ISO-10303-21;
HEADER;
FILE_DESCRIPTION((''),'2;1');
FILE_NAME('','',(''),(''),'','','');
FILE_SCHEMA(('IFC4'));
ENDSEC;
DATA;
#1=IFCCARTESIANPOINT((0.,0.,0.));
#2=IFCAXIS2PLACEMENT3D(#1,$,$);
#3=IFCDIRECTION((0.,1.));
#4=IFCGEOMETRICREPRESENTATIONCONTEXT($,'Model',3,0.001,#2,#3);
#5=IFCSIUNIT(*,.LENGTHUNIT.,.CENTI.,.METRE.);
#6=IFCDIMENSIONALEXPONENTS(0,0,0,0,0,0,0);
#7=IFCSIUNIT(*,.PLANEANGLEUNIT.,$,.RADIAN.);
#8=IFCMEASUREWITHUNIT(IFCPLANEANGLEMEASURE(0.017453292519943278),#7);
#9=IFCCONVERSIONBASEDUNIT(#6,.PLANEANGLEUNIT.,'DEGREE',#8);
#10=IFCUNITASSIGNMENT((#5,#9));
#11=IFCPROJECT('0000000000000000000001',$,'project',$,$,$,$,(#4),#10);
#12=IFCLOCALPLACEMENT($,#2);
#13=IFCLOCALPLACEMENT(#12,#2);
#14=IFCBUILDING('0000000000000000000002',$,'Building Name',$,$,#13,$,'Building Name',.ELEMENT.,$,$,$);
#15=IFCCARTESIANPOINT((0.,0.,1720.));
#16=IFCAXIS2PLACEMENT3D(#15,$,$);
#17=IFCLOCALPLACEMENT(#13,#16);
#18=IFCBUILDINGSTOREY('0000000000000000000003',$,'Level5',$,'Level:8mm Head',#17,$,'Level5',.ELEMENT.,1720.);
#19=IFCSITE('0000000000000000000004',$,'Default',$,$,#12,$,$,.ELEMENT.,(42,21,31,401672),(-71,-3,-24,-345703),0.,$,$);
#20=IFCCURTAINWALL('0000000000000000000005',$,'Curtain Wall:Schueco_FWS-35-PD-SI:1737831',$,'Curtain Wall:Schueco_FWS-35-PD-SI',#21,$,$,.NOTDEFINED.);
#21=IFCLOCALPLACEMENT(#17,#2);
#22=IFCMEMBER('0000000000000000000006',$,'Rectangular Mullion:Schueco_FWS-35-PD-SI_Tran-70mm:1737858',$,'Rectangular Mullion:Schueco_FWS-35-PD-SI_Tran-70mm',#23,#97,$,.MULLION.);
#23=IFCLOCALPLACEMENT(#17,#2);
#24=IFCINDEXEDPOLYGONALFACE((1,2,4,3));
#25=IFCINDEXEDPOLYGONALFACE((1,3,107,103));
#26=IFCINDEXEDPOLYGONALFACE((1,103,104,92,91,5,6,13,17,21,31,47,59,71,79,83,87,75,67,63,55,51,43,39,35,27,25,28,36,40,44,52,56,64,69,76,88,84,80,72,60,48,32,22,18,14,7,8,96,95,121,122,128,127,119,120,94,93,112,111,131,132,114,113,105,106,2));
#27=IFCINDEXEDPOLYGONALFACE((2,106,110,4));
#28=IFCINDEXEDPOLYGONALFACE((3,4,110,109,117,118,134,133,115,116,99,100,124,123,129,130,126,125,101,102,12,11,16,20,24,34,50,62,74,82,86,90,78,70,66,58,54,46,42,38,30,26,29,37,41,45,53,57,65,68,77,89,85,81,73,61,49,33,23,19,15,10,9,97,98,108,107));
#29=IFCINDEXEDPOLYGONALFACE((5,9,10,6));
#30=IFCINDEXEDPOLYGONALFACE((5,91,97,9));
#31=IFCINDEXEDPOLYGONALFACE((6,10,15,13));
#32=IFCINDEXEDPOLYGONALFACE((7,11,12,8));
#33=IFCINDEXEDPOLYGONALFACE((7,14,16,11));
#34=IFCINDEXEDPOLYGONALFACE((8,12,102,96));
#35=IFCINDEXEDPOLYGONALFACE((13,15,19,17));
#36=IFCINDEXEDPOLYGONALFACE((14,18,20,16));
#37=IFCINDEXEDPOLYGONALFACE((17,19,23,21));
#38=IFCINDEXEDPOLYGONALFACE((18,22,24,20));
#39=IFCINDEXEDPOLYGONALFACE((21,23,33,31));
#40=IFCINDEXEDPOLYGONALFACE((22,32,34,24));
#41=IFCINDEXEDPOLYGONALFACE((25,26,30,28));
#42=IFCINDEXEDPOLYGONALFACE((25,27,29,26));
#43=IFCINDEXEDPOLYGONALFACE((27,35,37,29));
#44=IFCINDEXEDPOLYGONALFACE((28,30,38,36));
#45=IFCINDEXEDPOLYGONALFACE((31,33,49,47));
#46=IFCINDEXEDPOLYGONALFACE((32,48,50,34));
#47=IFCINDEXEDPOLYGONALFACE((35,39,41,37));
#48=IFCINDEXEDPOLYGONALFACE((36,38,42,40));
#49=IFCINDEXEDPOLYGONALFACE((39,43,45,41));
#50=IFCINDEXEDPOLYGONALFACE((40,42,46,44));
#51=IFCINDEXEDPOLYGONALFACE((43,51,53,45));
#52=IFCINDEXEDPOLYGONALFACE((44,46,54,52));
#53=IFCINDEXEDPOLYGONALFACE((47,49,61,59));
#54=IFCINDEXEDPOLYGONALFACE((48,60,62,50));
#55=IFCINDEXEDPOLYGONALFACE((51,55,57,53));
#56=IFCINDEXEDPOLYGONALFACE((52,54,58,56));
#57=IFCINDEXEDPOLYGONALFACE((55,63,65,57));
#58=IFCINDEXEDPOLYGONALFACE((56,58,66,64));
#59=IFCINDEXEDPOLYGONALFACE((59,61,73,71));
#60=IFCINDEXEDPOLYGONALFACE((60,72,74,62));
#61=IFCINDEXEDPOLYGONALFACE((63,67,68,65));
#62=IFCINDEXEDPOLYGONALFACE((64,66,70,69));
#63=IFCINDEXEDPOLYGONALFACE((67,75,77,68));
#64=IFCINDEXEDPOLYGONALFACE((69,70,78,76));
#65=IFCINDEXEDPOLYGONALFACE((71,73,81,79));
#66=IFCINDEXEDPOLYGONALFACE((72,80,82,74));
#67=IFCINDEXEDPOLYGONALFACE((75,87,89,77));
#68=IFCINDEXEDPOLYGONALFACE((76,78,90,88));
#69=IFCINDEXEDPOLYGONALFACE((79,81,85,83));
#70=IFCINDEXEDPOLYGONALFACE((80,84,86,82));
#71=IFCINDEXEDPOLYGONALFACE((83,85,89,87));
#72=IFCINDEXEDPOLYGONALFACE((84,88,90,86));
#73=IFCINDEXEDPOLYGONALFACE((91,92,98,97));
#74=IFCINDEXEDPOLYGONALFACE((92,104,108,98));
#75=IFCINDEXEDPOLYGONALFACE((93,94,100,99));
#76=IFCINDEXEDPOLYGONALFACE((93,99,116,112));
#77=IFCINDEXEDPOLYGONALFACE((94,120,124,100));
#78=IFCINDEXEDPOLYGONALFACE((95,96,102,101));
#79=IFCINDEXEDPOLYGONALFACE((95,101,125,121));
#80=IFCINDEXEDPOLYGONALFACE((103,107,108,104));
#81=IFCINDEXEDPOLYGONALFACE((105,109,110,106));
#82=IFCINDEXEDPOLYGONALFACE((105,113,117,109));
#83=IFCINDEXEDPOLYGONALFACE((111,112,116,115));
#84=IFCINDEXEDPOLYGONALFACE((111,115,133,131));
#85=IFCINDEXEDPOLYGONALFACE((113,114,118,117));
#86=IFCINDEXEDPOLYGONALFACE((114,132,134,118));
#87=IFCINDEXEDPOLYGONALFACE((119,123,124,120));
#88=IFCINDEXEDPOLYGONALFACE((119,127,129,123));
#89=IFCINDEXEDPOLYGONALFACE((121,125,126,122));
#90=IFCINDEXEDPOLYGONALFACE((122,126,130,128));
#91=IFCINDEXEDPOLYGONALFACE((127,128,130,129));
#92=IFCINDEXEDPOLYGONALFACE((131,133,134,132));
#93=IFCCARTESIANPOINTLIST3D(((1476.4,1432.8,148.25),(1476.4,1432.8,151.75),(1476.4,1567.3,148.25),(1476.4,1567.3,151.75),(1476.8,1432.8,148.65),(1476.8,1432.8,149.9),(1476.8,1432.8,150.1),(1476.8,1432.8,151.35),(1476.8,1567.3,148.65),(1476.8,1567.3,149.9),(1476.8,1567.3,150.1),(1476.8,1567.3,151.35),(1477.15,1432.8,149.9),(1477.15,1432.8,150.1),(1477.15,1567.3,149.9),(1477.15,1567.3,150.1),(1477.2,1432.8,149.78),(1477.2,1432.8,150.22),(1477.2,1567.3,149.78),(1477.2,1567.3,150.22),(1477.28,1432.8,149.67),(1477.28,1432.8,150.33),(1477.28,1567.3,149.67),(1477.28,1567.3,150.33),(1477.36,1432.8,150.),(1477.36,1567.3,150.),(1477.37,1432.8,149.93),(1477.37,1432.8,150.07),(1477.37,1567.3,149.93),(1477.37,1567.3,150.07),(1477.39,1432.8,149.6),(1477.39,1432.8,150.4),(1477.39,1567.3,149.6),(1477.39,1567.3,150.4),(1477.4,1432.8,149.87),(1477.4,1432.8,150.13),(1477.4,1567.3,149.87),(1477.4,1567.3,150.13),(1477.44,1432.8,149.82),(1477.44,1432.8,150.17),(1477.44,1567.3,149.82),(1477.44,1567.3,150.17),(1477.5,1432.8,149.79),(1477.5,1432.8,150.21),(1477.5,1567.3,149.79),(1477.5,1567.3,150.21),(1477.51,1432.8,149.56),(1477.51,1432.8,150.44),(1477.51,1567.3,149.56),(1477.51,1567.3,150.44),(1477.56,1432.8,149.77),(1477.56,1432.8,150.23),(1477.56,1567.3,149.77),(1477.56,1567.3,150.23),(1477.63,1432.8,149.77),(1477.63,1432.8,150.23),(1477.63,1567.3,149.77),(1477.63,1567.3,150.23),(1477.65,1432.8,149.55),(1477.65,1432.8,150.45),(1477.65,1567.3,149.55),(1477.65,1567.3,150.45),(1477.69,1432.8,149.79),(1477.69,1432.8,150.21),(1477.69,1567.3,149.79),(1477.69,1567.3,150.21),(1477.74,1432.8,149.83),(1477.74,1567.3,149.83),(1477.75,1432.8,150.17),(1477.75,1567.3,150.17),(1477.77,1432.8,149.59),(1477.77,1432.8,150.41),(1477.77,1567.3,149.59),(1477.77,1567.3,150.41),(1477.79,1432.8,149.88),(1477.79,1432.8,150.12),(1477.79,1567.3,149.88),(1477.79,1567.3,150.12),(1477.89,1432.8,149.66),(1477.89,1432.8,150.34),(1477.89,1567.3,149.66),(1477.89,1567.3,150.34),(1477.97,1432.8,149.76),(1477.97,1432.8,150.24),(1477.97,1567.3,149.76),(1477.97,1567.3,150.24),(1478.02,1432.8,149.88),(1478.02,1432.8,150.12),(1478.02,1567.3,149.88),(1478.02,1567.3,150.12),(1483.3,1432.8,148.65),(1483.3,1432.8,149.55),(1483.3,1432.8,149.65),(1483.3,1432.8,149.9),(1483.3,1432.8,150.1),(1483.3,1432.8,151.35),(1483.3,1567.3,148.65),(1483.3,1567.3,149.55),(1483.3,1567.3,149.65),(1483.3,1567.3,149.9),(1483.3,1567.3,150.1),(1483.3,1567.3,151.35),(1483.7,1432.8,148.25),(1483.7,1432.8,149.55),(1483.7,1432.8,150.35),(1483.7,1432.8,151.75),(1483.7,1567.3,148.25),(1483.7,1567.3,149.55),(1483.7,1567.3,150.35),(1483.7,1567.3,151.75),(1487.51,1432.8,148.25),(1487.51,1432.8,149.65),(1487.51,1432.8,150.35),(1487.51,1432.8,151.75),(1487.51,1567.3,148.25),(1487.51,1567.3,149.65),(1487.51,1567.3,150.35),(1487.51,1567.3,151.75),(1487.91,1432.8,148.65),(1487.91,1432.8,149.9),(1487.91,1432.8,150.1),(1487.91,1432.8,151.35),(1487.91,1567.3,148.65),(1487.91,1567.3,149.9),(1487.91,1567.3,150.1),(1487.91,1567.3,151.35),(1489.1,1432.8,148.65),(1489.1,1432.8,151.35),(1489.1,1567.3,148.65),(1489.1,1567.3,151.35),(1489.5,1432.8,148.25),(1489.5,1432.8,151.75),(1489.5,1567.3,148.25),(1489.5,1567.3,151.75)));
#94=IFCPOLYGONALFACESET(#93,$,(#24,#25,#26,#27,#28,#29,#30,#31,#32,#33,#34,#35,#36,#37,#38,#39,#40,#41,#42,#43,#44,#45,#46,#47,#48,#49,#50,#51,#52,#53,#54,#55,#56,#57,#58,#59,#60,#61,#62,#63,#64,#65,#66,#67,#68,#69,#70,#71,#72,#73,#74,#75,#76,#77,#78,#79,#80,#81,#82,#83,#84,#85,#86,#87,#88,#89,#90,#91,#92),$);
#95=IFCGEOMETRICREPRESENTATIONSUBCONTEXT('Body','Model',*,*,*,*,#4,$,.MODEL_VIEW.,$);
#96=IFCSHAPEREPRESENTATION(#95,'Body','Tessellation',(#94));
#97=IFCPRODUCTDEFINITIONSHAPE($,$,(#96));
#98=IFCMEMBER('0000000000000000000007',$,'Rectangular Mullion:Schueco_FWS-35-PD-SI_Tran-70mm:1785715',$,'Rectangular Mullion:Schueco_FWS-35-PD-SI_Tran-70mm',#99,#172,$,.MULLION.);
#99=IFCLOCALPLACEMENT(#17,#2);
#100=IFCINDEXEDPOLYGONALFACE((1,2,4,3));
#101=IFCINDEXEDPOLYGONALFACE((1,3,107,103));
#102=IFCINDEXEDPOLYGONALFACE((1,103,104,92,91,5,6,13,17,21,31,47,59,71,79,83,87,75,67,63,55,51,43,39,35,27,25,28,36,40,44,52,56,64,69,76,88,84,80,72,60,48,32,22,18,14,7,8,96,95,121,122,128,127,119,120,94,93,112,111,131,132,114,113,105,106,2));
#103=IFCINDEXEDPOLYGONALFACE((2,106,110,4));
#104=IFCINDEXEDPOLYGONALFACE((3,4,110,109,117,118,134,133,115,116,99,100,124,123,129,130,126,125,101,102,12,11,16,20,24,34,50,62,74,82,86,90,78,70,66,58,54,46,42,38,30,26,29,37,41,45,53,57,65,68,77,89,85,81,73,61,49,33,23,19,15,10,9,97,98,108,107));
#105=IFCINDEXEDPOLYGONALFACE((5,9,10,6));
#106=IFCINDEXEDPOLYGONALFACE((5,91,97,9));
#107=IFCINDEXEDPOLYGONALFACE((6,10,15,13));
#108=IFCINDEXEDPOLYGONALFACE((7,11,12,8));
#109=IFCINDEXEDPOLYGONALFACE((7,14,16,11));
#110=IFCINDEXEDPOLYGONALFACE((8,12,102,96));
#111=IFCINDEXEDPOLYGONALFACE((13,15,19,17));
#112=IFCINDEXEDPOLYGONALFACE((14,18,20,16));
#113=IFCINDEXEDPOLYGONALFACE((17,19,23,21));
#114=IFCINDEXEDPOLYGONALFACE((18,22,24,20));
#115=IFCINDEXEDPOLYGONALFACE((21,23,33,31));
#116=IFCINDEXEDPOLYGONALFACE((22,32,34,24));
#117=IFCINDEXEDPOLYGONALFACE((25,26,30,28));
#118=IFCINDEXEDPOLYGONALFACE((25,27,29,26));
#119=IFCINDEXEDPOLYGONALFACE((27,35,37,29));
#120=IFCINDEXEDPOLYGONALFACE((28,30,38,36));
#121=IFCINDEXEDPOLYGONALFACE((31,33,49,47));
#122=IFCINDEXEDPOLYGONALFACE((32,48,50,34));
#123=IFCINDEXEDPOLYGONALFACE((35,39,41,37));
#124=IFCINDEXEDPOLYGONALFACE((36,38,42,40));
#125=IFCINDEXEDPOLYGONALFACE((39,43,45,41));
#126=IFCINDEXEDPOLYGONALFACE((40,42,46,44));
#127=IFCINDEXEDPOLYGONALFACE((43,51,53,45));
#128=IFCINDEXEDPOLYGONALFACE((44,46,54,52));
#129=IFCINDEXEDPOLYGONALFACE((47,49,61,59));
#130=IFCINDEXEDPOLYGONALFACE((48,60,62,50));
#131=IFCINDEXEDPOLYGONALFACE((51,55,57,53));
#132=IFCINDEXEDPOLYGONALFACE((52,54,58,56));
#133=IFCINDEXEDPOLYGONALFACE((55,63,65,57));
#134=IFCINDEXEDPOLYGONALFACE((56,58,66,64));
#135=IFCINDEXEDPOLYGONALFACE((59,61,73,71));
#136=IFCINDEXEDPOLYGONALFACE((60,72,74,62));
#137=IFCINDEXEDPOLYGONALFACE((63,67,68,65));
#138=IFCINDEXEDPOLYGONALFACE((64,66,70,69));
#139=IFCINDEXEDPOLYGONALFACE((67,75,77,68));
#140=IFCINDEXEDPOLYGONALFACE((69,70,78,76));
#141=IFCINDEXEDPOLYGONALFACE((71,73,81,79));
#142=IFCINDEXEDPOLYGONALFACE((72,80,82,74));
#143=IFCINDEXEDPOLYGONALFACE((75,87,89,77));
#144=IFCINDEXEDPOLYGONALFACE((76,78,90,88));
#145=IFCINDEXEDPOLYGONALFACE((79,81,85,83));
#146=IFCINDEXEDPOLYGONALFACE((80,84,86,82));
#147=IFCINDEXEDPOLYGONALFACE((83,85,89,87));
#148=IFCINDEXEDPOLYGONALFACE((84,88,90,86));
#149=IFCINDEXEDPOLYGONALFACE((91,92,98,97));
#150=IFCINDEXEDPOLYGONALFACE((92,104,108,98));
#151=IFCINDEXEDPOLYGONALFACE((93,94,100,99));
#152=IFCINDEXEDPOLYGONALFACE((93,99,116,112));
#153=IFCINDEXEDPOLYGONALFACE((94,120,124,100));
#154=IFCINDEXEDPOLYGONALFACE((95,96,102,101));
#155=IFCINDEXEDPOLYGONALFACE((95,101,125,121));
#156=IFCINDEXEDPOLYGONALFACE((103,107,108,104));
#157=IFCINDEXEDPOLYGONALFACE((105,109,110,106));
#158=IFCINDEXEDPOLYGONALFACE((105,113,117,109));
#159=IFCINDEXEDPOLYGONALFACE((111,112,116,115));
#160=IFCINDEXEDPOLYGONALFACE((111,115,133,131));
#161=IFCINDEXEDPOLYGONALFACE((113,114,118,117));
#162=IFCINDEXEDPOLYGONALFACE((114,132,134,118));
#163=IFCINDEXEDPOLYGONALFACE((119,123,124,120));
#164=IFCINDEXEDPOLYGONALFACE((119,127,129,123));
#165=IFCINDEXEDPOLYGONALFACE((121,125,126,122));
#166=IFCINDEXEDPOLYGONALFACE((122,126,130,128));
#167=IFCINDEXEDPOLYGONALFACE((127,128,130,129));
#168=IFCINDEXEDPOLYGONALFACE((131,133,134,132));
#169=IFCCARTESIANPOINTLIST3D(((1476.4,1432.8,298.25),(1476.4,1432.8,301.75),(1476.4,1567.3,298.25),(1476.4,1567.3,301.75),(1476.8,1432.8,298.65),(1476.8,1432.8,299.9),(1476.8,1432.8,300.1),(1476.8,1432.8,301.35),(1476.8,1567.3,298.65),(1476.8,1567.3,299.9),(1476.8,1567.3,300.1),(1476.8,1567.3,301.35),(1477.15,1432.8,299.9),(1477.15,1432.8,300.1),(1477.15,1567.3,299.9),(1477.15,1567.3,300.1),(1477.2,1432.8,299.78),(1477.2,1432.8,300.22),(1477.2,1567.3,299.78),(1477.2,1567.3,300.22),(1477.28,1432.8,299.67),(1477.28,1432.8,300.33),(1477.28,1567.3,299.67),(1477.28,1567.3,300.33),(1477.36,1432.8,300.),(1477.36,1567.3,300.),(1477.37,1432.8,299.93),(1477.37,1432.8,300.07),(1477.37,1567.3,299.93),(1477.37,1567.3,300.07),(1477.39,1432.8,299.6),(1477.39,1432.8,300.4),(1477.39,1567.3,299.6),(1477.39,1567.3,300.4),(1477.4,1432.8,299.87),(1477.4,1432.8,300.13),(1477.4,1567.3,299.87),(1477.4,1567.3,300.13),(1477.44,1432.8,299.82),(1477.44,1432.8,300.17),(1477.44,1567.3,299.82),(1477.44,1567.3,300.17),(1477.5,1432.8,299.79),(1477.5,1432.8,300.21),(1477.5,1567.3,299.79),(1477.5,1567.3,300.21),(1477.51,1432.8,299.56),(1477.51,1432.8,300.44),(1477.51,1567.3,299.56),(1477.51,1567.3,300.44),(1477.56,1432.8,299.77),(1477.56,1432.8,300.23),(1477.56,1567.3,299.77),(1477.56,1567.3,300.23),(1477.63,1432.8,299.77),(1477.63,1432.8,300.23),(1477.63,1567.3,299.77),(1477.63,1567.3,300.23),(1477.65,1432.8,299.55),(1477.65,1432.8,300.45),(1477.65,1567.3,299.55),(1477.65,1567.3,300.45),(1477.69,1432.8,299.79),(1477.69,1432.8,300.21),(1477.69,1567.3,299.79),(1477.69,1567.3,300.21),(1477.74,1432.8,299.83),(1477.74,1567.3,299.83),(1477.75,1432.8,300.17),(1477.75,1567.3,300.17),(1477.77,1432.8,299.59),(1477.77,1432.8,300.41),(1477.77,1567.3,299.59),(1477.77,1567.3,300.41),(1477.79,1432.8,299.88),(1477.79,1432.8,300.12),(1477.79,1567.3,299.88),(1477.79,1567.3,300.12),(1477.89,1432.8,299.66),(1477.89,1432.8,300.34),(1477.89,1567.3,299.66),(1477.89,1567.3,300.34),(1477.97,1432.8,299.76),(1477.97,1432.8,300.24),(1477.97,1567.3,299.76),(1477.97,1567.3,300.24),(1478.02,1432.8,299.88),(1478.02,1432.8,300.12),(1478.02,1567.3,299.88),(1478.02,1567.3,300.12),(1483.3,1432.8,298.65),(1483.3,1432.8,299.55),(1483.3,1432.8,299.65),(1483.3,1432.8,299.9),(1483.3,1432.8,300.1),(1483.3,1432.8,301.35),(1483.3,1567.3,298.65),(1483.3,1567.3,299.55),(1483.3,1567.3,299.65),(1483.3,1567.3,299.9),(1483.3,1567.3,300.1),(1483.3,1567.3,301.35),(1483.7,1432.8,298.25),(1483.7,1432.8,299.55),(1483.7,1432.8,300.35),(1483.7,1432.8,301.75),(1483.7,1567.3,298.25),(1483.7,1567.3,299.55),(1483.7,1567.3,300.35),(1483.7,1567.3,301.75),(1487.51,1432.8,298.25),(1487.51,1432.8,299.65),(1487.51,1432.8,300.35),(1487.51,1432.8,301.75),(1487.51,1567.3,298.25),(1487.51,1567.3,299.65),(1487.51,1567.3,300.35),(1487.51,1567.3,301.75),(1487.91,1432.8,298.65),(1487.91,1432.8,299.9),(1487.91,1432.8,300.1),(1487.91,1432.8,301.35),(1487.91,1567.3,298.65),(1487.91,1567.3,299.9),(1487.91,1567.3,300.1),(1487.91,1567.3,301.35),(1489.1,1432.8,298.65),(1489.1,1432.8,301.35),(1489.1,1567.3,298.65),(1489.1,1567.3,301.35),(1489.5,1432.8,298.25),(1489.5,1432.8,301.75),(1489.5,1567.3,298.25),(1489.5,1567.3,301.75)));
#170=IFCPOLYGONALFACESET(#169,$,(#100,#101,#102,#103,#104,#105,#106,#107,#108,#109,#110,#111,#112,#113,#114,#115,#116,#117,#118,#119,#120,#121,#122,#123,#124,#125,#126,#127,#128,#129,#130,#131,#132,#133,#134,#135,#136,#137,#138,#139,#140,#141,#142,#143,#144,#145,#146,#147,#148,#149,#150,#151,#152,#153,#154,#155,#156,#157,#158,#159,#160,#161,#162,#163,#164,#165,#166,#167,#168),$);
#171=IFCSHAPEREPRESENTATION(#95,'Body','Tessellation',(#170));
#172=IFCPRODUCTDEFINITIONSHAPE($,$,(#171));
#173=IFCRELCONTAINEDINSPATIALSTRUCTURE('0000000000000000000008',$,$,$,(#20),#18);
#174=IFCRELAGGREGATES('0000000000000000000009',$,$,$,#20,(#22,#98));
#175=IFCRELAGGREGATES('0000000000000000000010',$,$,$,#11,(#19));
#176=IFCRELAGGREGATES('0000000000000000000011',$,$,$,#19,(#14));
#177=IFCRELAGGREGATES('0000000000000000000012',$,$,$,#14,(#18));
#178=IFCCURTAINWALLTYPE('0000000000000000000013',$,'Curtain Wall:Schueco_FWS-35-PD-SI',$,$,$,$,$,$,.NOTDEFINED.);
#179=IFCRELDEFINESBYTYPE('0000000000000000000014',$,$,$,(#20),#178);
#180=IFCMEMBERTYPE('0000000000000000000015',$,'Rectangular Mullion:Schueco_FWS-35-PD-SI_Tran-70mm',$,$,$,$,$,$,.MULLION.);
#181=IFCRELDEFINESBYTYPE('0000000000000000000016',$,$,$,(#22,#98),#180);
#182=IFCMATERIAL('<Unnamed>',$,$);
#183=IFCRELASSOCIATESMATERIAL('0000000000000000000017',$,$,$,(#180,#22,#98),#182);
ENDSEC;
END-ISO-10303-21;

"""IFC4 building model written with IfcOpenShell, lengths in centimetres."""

from ifc_helpers import new_model, entity, si_unit, converted_unit, direction, frame, origin, place, context, subcontext, project, spatial, line, arc, indexed_curve, outline, extrude, source, transform, mapped, material, type_object, type_shapes, element, aggregate, save


model = new_model("IFC4")

# Units and contexts
model_context = context("Model", 3, precision=0.001, world=origin(), true_north=direction((0.0, 1.0)))
body_context = subcontext(model_context, "Body", "Model", "MODEL_VIEW")
ifc_project = project(units=[si_unit("LENGTHUNIT", "METRE", prefix="CENTI"), converted_unit("PLANEANGLEUNIT", "DEGREE", entity("IfcPlaneAngleMeasure", 0.017453292519943278), si_unit("PLANEANGLEUNIT", "RADIAN"), dimensions=[0, 0, 0, 0, 0, 0, 0])], contexts=[model_context])

# Site, building, storey
site_placement = place(None, origin())
site = spatial("IfcSite", under=ifc_project, at=site_placement, Name="Default", CompositionType="ELEMENT", RefLatitude=(42, 21, 31, 401672), RefLongitude=(-71, -3, -24, -345703), RefElevation=0.0)
building_placement = place(site_placement, origin())
building = spatial("IfcBuilding", under=site, at=building_placement, Name="Building Name", LongName="Building Name", CompositionType="ELEMENT")
storey_placement = place(building_placement, frame((0.0, 0.0, 1720.0)))
storey = spatial("IfcBuildingStorey", under=building, at=storey_placement, Name="Level5", ObjectType="Level:8mm Head", LongName="Level5", CompositionType="ELEMENT", Elevation=1720.0)

# Curtain wall, members
curtain_wall_type = type_object("IfcCurtainWallType", Name="Curtain Wall:Schueco_FWS-35-PD-SI", PredefinedType="NOTDEFINED")
curtain_wall_placement = place(storey_placement, frame((0.0, 0.0, -1720.0)))
curtain_wall = element("IfcCurtainWall", 1, at=curtain_wall_placement, inside=storey, type_object=curtain_wall_type, Name="Curtain Wall:Schueco_FWS-35-PD-SI:1737831", ObjectType="Curtain Wall:Schueco_FWS-35-PD-SI", PredefinedType="NOTDEFINED")
ifc_material_1 = material(Name="<Unnamed>")
member_type_1 = type_object("IfcMemberType", Name="Rectangular Mullion:Schueco_FWS-35-PD-SI_Tran-70mm", PredefinedType="MULLION", material=ifc_material_1)
shared_shape_1 = source(origin(), body_context, "Body", "SweptSolid", [
    extrude(outline(indexed_curve([(-1.78, -6.52), (1.72, -6.52), (1.72, 0.78), (0.42, 0.78), (0.42, 0.38), (1.32, 0.38), (1.32, -6.12), (0.07, -6.12), (0.07, -5.77), (0.42, -5.34), (0.09, -4.9), (0.09, -5.14), (-0.03, -5.56), (-0.15, -5.14), (-0.15, -4.9), (-0.48, -5.34), (-0.13, -5.77), (-0.13, -6.12), (-1.38, -6.12), (-1.38, 0.38), (-0.13, 0.38), (-0.13, 4.99), (-1.38, 4.99), (-1.38, 6.18), (1.32, 6.18), (1.32, 4.99), (0.07, 4.99), (0.07, 0.38), (0.32, 0.38), (0.32, 4.59), (1.72, 4.59), (1.72, 6.58), (-1.78, 6.58), (-1.78, 4.59), (-0.38, 4.59), (-0.38, 0.78), (-1.78, 0.78)], segments=[line(1, 2, 3, 4, 5, 6, 7, 8, 9), arc(9, 10, 11), line(11, 12), arc(12, 13, 14), line(14, 15), arc(15, 16, 17), line(17, 18, 19, 20, 21, 22, 23, 24, 25, 26, 27, 28, 29, 30, 31, 32, 33, 34, 35, 36, 37, 1)], self_intersect=False)), frame((-0.03, 4.58, -134.5), z_axis=(0.0, 0.0, 1.0), x_axis=(-1.0, 0.0, 0.0)), (0.0, 0.0, 1.0), 134.5),
])
type_shapes(member_type_1, [shared_shape_1])
member_1_placement = place(curtain_wall_placement, frame((1487.5, 1432.8, 1870.0), z_axis=(0.0, -1.0, 0.0), x_axis=(0.0, 0.0, 1.0)))
member_1 = element("IfcMember", 2, at=member_1_placement, type_object=member_type_1, material=ifc_material_1, Name="Rectangular Mullion:Schueco_FWS-35-PD-SI_Tran-70mm:1737858", ObjectType="Rectangular Mullion:Schueco_FWS-35-PD-SI_Tran-70mm", PredefinedType="MULLION", context=body_context, shape_type="MappedRepresentation", body=[
    mapped(shared_shape_1, transform((0.0, 0.0, 0.0), scale=1.0)),
])
member_2_placement = place(curtain_wall_placement, frame((1487.5, 1432.8, 2020.0), z_axis=(0.0, -1.0, 0.0), x_axis=(0.0, 0.0, 1.0)))
member_2 = element("IfcMember", 3, at=member_2_placement, type_object=member_type_1, material=ifc_material_1, Name="Rectangular Mullion:Schueco_FWS-35-PD-SI_Tran-70mm:1785715", ObjectType="Rectangular Mullion:Schueco_FWS-35-PD-SI_Tran-70mm", PredefinedType="MULLION", context=body_context, shape_type="MappedRepresentation", body=[
    mapped(shared_shape_1, transform((0.0, 0.0, 0.0), scale=1.0)),
])
aggregate(curtain_wall, [member_1, member_2])

save(model, "model.ifc")
